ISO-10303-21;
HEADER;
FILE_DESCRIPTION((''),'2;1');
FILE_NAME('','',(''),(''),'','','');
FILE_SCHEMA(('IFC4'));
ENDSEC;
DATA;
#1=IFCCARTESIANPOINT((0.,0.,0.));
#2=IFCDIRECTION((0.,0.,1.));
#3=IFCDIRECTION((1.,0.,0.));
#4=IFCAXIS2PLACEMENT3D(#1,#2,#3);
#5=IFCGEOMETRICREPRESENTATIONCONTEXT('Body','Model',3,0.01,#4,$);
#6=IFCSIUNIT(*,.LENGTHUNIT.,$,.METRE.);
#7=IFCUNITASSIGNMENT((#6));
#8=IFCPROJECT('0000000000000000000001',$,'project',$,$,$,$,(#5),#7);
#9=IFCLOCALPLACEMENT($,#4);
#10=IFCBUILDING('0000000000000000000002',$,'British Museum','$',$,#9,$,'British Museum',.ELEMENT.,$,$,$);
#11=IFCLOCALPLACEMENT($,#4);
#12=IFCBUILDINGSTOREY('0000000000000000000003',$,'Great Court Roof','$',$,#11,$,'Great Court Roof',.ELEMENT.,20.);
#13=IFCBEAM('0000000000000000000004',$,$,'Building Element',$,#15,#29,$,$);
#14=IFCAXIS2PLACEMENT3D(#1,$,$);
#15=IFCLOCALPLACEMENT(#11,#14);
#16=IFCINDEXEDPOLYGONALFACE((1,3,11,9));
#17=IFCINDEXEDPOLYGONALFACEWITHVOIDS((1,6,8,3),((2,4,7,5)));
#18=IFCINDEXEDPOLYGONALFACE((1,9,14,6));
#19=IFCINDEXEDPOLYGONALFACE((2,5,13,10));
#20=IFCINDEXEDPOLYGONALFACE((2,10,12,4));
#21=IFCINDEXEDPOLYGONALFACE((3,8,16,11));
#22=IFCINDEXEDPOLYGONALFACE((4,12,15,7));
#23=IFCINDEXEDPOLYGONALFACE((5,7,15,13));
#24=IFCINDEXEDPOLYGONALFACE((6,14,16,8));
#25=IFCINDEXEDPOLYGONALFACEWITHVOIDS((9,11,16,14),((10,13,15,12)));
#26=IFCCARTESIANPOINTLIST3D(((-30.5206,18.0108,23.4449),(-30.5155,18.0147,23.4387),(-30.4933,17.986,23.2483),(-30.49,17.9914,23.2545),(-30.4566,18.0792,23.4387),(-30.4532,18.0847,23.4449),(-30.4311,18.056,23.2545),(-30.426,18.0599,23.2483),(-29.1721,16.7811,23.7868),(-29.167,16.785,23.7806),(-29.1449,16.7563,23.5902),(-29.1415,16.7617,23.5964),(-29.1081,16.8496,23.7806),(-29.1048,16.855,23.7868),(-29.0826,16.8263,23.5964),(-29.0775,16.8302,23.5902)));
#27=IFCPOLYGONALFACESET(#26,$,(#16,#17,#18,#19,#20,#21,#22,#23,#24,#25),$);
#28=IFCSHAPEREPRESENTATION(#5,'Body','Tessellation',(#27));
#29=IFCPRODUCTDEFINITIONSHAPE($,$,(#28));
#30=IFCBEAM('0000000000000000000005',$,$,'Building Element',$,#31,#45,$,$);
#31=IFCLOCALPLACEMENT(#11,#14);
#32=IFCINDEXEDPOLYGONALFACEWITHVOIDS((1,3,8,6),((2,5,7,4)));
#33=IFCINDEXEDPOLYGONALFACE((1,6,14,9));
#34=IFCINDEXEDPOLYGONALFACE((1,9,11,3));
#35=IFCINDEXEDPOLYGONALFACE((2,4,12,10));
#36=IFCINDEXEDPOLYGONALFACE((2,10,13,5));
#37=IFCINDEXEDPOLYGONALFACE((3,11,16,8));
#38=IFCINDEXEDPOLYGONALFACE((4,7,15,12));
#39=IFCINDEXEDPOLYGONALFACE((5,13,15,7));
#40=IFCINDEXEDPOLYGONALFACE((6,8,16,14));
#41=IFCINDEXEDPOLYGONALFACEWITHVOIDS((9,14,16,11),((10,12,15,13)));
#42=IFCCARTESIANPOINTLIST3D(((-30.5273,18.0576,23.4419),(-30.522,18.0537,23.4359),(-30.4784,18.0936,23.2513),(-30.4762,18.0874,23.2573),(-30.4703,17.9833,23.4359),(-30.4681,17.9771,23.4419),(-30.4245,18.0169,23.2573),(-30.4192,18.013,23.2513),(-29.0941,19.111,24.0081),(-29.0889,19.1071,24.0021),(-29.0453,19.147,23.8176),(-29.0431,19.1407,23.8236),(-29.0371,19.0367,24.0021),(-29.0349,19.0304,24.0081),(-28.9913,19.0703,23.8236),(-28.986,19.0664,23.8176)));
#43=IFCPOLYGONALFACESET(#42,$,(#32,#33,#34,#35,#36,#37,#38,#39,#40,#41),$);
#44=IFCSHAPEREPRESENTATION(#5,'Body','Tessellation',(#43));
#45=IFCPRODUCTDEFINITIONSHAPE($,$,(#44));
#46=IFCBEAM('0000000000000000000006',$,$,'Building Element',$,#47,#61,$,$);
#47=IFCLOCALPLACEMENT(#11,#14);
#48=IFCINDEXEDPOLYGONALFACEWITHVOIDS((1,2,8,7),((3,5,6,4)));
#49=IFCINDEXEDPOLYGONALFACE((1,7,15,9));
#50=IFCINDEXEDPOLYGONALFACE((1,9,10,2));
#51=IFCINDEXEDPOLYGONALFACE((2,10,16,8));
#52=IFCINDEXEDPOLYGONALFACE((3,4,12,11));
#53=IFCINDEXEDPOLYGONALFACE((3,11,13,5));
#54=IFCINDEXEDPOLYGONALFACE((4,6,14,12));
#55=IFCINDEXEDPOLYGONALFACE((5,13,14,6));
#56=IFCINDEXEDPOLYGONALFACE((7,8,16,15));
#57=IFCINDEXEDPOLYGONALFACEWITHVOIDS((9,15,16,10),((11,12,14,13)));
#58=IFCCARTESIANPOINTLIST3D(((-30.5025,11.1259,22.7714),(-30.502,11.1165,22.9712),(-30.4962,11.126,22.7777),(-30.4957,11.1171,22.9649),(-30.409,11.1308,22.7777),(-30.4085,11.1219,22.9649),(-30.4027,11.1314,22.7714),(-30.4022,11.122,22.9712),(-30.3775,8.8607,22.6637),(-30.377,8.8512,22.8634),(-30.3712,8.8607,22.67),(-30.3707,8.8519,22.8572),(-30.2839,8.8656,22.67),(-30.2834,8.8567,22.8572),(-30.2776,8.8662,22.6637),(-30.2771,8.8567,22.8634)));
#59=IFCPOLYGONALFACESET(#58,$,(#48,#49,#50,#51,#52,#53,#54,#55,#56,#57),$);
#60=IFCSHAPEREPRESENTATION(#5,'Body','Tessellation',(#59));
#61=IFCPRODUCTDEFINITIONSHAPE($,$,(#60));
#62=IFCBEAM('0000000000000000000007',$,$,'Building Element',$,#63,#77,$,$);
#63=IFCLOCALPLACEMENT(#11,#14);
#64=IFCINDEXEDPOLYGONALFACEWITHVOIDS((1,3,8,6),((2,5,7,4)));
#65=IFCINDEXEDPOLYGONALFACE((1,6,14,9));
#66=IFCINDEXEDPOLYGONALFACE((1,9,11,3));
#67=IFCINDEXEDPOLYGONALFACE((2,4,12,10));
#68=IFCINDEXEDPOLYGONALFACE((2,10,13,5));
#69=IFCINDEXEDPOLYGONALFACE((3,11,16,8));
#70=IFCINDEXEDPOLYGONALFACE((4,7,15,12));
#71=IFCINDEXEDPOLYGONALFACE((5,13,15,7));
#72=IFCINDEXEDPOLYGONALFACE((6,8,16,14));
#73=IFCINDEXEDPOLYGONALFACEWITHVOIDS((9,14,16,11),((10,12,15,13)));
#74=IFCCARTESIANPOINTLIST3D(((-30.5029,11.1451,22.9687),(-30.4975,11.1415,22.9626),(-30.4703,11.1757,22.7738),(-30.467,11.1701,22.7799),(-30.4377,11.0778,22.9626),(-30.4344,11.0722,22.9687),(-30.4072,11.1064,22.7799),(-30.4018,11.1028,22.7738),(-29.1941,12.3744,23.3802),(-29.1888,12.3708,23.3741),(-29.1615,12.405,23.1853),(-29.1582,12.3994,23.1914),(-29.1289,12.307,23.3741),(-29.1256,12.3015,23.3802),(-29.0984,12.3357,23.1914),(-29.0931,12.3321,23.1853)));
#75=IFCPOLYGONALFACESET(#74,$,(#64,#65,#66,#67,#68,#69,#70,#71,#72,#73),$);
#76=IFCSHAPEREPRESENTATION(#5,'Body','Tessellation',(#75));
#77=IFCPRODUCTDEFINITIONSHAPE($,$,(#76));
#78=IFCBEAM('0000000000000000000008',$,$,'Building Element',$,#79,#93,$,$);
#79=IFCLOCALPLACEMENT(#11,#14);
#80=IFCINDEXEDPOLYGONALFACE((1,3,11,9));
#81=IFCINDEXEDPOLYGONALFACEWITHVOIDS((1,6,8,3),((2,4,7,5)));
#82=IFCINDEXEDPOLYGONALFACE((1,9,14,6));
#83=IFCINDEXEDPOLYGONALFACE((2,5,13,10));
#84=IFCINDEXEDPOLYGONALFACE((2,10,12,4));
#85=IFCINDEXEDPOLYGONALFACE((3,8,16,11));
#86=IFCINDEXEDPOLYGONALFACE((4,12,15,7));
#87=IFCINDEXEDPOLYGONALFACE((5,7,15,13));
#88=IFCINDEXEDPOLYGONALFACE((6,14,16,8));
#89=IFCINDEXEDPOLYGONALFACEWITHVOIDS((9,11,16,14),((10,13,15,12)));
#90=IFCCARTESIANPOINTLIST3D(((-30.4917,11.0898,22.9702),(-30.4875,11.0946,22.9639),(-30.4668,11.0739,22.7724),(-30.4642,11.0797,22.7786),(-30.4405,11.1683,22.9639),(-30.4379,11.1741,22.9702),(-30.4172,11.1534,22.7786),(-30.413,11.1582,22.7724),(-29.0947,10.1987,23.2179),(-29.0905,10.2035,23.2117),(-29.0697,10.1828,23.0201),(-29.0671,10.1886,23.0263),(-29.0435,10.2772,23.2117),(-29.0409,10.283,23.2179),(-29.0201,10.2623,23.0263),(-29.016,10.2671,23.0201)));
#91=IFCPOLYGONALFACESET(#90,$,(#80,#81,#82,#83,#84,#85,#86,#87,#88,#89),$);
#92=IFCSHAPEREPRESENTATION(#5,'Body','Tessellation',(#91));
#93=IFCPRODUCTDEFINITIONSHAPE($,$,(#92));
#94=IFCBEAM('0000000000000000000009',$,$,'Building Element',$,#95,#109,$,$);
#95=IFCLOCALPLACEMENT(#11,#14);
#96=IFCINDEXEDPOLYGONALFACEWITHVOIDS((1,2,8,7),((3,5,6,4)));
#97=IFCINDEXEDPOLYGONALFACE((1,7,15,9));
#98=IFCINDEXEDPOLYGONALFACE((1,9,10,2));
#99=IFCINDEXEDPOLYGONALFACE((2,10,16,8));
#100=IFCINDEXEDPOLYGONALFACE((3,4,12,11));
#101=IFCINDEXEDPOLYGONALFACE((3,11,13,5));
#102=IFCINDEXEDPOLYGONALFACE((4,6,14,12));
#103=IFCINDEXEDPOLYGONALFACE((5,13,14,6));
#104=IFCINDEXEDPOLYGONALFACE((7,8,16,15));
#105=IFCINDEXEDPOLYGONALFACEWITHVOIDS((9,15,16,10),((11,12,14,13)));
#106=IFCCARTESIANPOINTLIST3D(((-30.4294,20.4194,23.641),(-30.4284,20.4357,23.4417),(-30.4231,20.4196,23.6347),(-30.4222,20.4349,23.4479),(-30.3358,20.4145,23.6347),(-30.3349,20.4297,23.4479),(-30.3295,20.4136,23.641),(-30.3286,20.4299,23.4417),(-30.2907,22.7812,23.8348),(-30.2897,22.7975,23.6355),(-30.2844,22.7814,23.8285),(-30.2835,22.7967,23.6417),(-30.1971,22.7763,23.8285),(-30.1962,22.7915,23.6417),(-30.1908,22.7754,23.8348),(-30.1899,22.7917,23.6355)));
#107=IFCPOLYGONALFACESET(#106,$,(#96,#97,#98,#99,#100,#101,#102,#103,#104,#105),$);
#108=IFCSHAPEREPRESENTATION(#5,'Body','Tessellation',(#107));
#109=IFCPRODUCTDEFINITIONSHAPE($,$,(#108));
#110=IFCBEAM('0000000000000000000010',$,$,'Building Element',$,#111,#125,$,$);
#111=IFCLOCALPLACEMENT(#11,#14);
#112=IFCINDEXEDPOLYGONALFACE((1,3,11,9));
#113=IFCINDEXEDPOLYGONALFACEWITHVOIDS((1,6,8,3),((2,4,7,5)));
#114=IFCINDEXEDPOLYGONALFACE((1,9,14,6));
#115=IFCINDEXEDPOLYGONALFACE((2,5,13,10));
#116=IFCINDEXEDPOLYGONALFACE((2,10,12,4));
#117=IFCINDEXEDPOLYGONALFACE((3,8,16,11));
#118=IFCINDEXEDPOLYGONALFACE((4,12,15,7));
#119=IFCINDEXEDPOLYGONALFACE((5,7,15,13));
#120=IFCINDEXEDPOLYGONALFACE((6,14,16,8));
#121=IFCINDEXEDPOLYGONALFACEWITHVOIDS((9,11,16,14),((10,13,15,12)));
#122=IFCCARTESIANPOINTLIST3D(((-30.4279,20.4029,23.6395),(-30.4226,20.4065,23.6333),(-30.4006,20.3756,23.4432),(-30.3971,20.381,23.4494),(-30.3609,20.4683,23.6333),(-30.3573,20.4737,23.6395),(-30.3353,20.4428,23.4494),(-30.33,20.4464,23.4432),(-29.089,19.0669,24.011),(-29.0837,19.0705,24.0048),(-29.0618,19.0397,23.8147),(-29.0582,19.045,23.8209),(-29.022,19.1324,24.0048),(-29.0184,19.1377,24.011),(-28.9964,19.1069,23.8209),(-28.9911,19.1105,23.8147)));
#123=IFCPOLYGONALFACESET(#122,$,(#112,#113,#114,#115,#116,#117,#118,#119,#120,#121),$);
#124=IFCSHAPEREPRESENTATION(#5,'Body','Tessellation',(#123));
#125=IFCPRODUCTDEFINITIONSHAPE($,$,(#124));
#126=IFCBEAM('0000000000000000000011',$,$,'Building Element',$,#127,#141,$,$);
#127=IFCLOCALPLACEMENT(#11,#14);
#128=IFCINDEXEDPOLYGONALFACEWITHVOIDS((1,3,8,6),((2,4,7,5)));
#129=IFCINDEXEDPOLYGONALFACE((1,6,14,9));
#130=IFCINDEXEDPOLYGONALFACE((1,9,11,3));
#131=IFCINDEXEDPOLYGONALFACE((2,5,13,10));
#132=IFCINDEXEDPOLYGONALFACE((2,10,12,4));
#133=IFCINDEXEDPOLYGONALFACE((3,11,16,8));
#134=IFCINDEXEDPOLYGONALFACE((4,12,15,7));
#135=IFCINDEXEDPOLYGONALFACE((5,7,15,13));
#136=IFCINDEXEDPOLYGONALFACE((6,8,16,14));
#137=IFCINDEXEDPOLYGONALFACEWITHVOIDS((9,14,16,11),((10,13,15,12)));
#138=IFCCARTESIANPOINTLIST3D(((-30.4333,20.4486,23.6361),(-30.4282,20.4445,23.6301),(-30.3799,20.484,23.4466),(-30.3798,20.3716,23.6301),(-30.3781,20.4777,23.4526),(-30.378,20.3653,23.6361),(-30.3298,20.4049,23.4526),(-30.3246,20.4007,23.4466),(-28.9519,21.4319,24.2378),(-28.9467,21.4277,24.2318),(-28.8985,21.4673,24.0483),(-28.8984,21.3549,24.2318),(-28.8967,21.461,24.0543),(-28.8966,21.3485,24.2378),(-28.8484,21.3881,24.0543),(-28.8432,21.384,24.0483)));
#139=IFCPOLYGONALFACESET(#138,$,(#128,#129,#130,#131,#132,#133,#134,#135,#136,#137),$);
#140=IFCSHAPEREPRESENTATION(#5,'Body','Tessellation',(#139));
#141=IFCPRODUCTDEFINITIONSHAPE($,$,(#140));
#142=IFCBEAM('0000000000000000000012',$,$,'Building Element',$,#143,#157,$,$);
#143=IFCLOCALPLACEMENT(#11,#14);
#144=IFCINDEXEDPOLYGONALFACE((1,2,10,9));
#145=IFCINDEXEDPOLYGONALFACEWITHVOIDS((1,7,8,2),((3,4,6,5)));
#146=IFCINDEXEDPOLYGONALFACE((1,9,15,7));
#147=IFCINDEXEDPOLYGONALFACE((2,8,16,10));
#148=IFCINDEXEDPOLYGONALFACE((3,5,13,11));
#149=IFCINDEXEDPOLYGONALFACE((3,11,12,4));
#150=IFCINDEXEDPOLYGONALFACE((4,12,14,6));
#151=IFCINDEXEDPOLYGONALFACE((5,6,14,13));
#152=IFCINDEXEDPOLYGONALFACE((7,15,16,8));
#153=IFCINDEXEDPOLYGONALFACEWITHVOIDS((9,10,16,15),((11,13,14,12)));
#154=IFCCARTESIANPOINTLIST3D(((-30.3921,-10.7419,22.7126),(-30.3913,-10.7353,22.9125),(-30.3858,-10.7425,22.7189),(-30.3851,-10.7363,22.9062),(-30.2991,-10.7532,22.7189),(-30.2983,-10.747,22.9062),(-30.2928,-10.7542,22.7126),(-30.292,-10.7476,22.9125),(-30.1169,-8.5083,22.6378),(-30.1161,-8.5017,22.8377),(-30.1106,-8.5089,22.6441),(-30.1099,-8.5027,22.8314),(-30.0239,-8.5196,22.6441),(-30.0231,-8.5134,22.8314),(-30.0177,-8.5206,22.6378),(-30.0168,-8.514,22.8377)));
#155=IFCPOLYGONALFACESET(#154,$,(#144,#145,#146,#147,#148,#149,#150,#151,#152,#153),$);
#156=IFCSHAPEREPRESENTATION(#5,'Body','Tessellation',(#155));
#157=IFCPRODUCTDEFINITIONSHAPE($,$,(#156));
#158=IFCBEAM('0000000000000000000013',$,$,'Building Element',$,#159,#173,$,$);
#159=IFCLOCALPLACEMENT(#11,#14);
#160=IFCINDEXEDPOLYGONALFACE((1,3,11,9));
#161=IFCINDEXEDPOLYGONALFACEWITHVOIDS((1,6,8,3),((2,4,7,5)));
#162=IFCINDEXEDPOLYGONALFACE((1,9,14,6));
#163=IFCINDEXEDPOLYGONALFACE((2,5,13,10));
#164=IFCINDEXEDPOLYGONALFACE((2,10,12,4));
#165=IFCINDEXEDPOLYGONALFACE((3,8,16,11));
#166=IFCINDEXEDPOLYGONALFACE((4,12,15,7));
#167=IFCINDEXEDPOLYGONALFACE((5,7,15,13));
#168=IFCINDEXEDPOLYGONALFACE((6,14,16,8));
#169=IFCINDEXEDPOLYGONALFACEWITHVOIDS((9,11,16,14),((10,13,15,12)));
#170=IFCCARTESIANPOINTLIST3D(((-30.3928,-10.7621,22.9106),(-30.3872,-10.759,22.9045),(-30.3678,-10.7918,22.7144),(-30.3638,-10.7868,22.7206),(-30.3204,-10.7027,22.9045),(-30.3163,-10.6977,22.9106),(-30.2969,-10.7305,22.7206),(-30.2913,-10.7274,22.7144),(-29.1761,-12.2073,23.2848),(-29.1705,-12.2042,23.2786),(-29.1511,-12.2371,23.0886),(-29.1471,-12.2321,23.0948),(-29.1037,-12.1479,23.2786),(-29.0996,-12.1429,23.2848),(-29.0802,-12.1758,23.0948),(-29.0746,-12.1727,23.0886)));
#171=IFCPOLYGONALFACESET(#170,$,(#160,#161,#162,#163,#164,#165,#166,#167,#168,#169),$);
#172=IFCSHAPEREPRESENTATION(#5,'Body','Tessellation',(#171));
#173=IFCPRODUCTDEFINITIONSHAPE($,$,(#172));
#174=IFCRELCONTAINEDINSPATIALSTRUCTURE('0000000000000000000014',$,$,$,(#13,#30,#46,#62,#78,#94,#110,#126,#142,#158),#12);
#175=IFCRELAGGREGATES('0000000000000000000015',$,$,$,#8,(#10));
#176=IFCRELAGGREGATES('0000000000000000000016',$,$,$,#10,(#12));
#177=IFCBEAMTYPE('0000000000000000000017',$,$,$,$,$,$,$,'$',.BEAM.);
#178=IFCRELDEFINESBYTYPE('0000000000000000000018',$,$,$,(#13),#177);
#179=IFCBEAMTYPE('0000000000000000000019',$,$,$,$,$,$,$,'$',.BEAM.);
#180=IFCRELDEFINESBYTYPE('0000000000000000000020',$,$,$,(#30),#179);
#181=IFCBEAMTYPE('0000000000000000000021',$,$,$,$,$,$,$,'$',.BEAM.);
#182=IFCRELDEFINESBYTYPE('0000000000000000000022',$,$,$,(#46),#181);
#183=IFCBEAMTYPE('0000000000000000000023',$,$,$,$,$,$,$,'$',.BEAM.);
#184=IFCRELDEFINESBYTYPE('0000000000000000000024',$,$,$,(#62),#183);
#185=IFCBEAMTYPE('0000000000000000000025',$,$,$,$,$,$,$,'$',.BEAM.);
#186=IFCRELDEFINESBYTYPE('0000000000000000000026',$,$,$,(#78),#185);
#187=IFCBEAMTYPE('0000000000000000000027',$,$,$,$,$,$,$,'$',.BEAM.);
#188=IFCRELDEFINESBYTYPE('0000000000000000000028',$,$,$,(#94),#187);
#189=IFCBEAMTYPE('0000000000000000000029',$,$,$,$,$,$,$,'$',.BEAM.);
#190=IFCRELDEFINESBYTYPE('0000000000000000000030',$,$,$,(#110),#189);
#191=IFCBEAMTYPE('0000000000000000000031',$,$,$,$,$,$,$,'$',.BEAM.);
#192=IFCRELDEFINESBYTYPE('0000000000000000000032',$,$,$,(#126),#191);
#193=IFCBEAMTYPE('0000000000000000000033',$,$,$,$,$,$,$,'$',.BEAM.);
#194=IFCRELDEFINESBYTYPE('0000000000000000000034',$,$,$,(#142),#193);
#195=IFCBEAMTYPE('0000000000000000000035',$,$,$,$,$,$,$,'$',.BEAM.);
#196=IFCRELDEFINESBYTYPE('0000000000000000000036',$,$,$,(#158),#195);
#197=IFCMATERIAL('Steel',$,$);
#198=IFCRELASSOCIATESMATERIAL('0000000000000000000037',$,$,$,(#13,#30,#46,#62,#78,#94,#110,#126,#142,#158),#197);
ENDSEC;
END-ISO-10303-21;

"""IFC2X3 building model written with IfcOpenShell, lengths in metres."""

from ifc_helpers import new_model, si_unit, frame, origin_with_axes, origin_2d, place, context, project, spatial, hollow_rectangle, extrude, material, type_object, element, save


model = new_model("IFC2X3")

# Units and contexts
model_context = context("Model", 3, precision=0.01, world=origin_with_axes(), identifier="Body")
ifc_project = project(units=[si_unit("LENGTHUNIT", "METRE")], contexts=[model_context])

# Building, storey
building_placement = place(None, origin_with_axes())
building = spatial("IfcBuilding", under=ifc_project, at=building_placement, Name="British Museum", Description="$", LongName="British Museum", CompositionType="ELEMENT")
storey_placement = place(None, origin_with_axes())
storey = spatial("IfcBuildingStorey", under=building, at=storey_placement, Name="Great Court Roof", Description="$", LongName="Great Court Roof", CompositionType="ELEMENT", Elevation=20.0)

# Beams
ifc_material = material(Name="Steel")
beam_type_1 = type_object("IfcBeamType", ElementType="$", PredefinedType="BEAM")
beam_1_placement = place(None, origin_with_axes())
element("IfcBeam", 1, at=beam_1_placement, inside=storey, type_object=beam_type_1, material=ifc_material, Description="Building Element", context=model_context, shape_type="SweptSolid", body=[
    extrude(hollow_rectangle(XDim=0.1, YDim=0.2, WallThickness=0.0063, InnerFilletRadius=0.0, OuterFilletRadius=0.0, at=origin_2d()), frame((-30.4733, 18.0353, 23.3466), z_axis=(0.726253, -0.662299, 0.184164), x_axis=(0.673825, 0.738891, 0.0)), (0.0, 0.0, 1.0), 1.8567),
])
beam_type_2 = type_object("IfcBeamType", ElementType="$", PredefinedType="BEAM")
beam_2_placement = place(None, origin_with_axes())
element("IfcBeam", 2, at=beam_2_placement, inside=storey, type_object=beam_type_2, material=ifc_material, Description="Building Element", context=model_context, shape_type="SweptSolid", body=[
    extrude(hollow_rectangle(XDim=0.1, YDim=0.2, WallThickness=0.0063, InnerFilletRadius=0.0, OuterFilletRadius=0.0, at=origin_2d()), frame((-30.4733, 18.0353, 23.3466), z_axis=(0.767792, 0.564324, 0.30337), x_axis=(-0.592234, 0.805766, 0.0)), (0.0, 0.0, 1.0), 1.8666),
])
beam_type_3 = type_object("IfcBeamType", ElementType="$", PredefinedType="BEAM")
beam_3_placement = place(None, origin_with_axes())
element("IfcBeam", 3, at=beam_3_placement, inside=storey, type_object=beam_type_3, material=ifc_material, Description="Building Element", context=model_context, shape_type="SweptSolid", body=[
    extrude(hollow_rectangle(XDim=0.1, YDim=0.2, WallThickness=0.0063, InnerFilletRadius=0.0, OuterFilletRadius=0.0, at=origin_2d()), frame((-30.4523, 11.124, 22.8713), z_axis=(0.05505, -0.997357, -0.047422), x_axis=(0.99848, 0.055112, 0.0)), (0.0, 0.0, 1.0), 2.2712),
])
beam_type_4 = type_object("IfcBeamType", ElementType="$", PredefinedType="BEAM")
beam_4_placement = place(None, origin_with_axes())
element("IfcBeam", 4, at=beam_4_placement, inside=storey, type_object=beam_type_4, material=ifc_material, Description="Building Element", context=model_context, shape_type="SweptSolid", body=[
    extrude(hollow_rectangle(XDim=0.1, YDim=0.2, WallThickness=0.0063, InnerFilletRadius=0.0, OuterFilletRadius=0.0, at=origin_2d()), frame((-30.4523, 11.124, 22.8713), z_axis=(0.710476, 0.667324, 0.223389), x_axis=(-0.684625, 0.728895, 0.0)), (0.0, 0.0, 1.0), 1.8421),
])
beam_type_5 = type_object("IfcBeamType", ElementType="$", PredefinedType="BEAM")
beam_5_placement = place(None, origin_with_axes())
element("IfcBeam", 5, at=beam_5_placement, inside=storey, type_object=beam_type_5, material=ifc_material, Description="Building Element", context=model_context, shape_type="SweptSolid", body=[
    extrude(hollow_rectangle(XDim=0.1, YDim=0.2, WallThickness=0.0063, InnerFilletRadius=0.0, OuterFilletRadius=0.0, at=origin_2d()), frame((-30.4523, 11.124, 22.8713), z_axis=(0.833838, -0.531839, 0.147853), x_axis=(0.537749, 0.843105, 0.0)), (0.0, 0.0, 1.0), 1.6754),
])
beam_type_6 = type_object("IfcBeamType", ElementType="$", PredefinedType="BEAM")
beam_6_placement = place(None, origin_with_axes())
element("IfcBeam", 6, at=beam_6_placement, inside=storey, type_object=beam_type_6, material=ifc_material, Description="Building Element", context=model_context, shape_type="SweptSolid", body=[
    extrude(hollow_rectangle(XDim=0.1, YDim=0.2, WallThickness=0.0063, InnerFilletRadius=0.0, OuterFilletRadius=0.0, at=origin_2d()), frame((-30.379, 20.4247, 23.5413), z_axis=(0.058426, 0.994948, 0.081639), x_axis=(-0.99828, 0.058622, 0.0)), (0.0, 0.0, 1.0), 2.3738),
])
beam_type_7 = type_object("IfcBeamType", ElementType="$", PredefinedType="BEAM")
beam_7_placement = place(None, origin_with_axes())
element("IfcBeam", 7, at=beam_7_placement, inside=storey, type_object=beam_type_7, material=ifc_material, Description="Building Element", context=model_context, shape_type="SweptSolid", body=[
    extrude(hollow_rectangle(XDim=0.1, YDim=0.2, WallThickness=0.0063, InnerFilletRadius=0.0, OuterFilletRadius=0.0, at=origin_2d()), frame((-30.379, 20.4247, 23.5413), z_axis=(0.694608, -0.693087, 0.192744), x_axis=(0.706331, 0.707882, 0.0)), (0.0, 0.0, 1.0), 1.9275),
])
beam_type_8 = type_object("IfcBeamType", ElementType="$", PredefinedType="BEAM")
beam_8_placement = place(None, origin_with_axes())
element("IfcBeam", 8, at=beam_8_placement, inside=storey, type_object=beam_type_8, material=ifc_material, Description="Building Element", context=model_context, shape_type="SweptSolid", body=[
    extrude(hollow_rectangle(XDim=0.1, YDim=0.2, WallThickness=0.0063, InnerFilletRadius=0.0, OuterFilletRadius=0.0, at=origin_2d()), frame((-30.379, 20.4247, 23.5413), z_axis=(0.789209, 0.523828, 0.320552), x_axis=(-0.553009, 0.833175, 0.0)), (0.0, 0.0, 1.0), 1.8771),
])
beam_type_9 = type_object("IfcBeamType", ElementType="$", PredefinedType="BEAM")
beam_9_placement = place(None, origin_with_axes())
element("IfcBeam", 9, at=beam_9_placement, inside=storey, type_object=beam_type_9, material=ifc_material, Description="Building Element", context=model_context, shape_type="SweptSolid", body=[
    extrude(hollow_rectangle(XDim=0.1, YDim=0.2, WallThickness=0.0063, InnerFilletRadius=0.0, OuterFilletRadius=0.0, at=origin_2d()), frame((-30.3421, -10.7447, 22.8125), z_axis=(0.122214, 0.991948, -0.033224), x_axis=(-0.992495, 0.122281, 0.0)), (0.0, 0.0, 1.0), 2.2517),
])
beam_type_10 = type_object("IfcBeamType", ElementType="$", PredefinedType="BEAM")
beam_10_placement = place(None, origin_with_axes())
element("IfcBeam", 10, at=beam_10_placement, inside=storey, type_object=beam_type_10, material=ifc_material, Description="Building Element", context=model_context, shape_type="SweptSolid", body=[
    extrude(hollow_rectangle(XDim=0.1, YDim=0.2, WallThickness=0.0063, InnerFilletRadius=0.0, OuterFilletRadius=0.0, at=origin_2d()), frame((-30.3421, -10.7447, 22.8125), z_axis=(0.631744, -0.750434, 0.194291), x_axis=(0.765012, 0.644016, 0.0)), (0.0, 0.0, 1.0), 1.9259),
])

save(model, "model.ifc")
